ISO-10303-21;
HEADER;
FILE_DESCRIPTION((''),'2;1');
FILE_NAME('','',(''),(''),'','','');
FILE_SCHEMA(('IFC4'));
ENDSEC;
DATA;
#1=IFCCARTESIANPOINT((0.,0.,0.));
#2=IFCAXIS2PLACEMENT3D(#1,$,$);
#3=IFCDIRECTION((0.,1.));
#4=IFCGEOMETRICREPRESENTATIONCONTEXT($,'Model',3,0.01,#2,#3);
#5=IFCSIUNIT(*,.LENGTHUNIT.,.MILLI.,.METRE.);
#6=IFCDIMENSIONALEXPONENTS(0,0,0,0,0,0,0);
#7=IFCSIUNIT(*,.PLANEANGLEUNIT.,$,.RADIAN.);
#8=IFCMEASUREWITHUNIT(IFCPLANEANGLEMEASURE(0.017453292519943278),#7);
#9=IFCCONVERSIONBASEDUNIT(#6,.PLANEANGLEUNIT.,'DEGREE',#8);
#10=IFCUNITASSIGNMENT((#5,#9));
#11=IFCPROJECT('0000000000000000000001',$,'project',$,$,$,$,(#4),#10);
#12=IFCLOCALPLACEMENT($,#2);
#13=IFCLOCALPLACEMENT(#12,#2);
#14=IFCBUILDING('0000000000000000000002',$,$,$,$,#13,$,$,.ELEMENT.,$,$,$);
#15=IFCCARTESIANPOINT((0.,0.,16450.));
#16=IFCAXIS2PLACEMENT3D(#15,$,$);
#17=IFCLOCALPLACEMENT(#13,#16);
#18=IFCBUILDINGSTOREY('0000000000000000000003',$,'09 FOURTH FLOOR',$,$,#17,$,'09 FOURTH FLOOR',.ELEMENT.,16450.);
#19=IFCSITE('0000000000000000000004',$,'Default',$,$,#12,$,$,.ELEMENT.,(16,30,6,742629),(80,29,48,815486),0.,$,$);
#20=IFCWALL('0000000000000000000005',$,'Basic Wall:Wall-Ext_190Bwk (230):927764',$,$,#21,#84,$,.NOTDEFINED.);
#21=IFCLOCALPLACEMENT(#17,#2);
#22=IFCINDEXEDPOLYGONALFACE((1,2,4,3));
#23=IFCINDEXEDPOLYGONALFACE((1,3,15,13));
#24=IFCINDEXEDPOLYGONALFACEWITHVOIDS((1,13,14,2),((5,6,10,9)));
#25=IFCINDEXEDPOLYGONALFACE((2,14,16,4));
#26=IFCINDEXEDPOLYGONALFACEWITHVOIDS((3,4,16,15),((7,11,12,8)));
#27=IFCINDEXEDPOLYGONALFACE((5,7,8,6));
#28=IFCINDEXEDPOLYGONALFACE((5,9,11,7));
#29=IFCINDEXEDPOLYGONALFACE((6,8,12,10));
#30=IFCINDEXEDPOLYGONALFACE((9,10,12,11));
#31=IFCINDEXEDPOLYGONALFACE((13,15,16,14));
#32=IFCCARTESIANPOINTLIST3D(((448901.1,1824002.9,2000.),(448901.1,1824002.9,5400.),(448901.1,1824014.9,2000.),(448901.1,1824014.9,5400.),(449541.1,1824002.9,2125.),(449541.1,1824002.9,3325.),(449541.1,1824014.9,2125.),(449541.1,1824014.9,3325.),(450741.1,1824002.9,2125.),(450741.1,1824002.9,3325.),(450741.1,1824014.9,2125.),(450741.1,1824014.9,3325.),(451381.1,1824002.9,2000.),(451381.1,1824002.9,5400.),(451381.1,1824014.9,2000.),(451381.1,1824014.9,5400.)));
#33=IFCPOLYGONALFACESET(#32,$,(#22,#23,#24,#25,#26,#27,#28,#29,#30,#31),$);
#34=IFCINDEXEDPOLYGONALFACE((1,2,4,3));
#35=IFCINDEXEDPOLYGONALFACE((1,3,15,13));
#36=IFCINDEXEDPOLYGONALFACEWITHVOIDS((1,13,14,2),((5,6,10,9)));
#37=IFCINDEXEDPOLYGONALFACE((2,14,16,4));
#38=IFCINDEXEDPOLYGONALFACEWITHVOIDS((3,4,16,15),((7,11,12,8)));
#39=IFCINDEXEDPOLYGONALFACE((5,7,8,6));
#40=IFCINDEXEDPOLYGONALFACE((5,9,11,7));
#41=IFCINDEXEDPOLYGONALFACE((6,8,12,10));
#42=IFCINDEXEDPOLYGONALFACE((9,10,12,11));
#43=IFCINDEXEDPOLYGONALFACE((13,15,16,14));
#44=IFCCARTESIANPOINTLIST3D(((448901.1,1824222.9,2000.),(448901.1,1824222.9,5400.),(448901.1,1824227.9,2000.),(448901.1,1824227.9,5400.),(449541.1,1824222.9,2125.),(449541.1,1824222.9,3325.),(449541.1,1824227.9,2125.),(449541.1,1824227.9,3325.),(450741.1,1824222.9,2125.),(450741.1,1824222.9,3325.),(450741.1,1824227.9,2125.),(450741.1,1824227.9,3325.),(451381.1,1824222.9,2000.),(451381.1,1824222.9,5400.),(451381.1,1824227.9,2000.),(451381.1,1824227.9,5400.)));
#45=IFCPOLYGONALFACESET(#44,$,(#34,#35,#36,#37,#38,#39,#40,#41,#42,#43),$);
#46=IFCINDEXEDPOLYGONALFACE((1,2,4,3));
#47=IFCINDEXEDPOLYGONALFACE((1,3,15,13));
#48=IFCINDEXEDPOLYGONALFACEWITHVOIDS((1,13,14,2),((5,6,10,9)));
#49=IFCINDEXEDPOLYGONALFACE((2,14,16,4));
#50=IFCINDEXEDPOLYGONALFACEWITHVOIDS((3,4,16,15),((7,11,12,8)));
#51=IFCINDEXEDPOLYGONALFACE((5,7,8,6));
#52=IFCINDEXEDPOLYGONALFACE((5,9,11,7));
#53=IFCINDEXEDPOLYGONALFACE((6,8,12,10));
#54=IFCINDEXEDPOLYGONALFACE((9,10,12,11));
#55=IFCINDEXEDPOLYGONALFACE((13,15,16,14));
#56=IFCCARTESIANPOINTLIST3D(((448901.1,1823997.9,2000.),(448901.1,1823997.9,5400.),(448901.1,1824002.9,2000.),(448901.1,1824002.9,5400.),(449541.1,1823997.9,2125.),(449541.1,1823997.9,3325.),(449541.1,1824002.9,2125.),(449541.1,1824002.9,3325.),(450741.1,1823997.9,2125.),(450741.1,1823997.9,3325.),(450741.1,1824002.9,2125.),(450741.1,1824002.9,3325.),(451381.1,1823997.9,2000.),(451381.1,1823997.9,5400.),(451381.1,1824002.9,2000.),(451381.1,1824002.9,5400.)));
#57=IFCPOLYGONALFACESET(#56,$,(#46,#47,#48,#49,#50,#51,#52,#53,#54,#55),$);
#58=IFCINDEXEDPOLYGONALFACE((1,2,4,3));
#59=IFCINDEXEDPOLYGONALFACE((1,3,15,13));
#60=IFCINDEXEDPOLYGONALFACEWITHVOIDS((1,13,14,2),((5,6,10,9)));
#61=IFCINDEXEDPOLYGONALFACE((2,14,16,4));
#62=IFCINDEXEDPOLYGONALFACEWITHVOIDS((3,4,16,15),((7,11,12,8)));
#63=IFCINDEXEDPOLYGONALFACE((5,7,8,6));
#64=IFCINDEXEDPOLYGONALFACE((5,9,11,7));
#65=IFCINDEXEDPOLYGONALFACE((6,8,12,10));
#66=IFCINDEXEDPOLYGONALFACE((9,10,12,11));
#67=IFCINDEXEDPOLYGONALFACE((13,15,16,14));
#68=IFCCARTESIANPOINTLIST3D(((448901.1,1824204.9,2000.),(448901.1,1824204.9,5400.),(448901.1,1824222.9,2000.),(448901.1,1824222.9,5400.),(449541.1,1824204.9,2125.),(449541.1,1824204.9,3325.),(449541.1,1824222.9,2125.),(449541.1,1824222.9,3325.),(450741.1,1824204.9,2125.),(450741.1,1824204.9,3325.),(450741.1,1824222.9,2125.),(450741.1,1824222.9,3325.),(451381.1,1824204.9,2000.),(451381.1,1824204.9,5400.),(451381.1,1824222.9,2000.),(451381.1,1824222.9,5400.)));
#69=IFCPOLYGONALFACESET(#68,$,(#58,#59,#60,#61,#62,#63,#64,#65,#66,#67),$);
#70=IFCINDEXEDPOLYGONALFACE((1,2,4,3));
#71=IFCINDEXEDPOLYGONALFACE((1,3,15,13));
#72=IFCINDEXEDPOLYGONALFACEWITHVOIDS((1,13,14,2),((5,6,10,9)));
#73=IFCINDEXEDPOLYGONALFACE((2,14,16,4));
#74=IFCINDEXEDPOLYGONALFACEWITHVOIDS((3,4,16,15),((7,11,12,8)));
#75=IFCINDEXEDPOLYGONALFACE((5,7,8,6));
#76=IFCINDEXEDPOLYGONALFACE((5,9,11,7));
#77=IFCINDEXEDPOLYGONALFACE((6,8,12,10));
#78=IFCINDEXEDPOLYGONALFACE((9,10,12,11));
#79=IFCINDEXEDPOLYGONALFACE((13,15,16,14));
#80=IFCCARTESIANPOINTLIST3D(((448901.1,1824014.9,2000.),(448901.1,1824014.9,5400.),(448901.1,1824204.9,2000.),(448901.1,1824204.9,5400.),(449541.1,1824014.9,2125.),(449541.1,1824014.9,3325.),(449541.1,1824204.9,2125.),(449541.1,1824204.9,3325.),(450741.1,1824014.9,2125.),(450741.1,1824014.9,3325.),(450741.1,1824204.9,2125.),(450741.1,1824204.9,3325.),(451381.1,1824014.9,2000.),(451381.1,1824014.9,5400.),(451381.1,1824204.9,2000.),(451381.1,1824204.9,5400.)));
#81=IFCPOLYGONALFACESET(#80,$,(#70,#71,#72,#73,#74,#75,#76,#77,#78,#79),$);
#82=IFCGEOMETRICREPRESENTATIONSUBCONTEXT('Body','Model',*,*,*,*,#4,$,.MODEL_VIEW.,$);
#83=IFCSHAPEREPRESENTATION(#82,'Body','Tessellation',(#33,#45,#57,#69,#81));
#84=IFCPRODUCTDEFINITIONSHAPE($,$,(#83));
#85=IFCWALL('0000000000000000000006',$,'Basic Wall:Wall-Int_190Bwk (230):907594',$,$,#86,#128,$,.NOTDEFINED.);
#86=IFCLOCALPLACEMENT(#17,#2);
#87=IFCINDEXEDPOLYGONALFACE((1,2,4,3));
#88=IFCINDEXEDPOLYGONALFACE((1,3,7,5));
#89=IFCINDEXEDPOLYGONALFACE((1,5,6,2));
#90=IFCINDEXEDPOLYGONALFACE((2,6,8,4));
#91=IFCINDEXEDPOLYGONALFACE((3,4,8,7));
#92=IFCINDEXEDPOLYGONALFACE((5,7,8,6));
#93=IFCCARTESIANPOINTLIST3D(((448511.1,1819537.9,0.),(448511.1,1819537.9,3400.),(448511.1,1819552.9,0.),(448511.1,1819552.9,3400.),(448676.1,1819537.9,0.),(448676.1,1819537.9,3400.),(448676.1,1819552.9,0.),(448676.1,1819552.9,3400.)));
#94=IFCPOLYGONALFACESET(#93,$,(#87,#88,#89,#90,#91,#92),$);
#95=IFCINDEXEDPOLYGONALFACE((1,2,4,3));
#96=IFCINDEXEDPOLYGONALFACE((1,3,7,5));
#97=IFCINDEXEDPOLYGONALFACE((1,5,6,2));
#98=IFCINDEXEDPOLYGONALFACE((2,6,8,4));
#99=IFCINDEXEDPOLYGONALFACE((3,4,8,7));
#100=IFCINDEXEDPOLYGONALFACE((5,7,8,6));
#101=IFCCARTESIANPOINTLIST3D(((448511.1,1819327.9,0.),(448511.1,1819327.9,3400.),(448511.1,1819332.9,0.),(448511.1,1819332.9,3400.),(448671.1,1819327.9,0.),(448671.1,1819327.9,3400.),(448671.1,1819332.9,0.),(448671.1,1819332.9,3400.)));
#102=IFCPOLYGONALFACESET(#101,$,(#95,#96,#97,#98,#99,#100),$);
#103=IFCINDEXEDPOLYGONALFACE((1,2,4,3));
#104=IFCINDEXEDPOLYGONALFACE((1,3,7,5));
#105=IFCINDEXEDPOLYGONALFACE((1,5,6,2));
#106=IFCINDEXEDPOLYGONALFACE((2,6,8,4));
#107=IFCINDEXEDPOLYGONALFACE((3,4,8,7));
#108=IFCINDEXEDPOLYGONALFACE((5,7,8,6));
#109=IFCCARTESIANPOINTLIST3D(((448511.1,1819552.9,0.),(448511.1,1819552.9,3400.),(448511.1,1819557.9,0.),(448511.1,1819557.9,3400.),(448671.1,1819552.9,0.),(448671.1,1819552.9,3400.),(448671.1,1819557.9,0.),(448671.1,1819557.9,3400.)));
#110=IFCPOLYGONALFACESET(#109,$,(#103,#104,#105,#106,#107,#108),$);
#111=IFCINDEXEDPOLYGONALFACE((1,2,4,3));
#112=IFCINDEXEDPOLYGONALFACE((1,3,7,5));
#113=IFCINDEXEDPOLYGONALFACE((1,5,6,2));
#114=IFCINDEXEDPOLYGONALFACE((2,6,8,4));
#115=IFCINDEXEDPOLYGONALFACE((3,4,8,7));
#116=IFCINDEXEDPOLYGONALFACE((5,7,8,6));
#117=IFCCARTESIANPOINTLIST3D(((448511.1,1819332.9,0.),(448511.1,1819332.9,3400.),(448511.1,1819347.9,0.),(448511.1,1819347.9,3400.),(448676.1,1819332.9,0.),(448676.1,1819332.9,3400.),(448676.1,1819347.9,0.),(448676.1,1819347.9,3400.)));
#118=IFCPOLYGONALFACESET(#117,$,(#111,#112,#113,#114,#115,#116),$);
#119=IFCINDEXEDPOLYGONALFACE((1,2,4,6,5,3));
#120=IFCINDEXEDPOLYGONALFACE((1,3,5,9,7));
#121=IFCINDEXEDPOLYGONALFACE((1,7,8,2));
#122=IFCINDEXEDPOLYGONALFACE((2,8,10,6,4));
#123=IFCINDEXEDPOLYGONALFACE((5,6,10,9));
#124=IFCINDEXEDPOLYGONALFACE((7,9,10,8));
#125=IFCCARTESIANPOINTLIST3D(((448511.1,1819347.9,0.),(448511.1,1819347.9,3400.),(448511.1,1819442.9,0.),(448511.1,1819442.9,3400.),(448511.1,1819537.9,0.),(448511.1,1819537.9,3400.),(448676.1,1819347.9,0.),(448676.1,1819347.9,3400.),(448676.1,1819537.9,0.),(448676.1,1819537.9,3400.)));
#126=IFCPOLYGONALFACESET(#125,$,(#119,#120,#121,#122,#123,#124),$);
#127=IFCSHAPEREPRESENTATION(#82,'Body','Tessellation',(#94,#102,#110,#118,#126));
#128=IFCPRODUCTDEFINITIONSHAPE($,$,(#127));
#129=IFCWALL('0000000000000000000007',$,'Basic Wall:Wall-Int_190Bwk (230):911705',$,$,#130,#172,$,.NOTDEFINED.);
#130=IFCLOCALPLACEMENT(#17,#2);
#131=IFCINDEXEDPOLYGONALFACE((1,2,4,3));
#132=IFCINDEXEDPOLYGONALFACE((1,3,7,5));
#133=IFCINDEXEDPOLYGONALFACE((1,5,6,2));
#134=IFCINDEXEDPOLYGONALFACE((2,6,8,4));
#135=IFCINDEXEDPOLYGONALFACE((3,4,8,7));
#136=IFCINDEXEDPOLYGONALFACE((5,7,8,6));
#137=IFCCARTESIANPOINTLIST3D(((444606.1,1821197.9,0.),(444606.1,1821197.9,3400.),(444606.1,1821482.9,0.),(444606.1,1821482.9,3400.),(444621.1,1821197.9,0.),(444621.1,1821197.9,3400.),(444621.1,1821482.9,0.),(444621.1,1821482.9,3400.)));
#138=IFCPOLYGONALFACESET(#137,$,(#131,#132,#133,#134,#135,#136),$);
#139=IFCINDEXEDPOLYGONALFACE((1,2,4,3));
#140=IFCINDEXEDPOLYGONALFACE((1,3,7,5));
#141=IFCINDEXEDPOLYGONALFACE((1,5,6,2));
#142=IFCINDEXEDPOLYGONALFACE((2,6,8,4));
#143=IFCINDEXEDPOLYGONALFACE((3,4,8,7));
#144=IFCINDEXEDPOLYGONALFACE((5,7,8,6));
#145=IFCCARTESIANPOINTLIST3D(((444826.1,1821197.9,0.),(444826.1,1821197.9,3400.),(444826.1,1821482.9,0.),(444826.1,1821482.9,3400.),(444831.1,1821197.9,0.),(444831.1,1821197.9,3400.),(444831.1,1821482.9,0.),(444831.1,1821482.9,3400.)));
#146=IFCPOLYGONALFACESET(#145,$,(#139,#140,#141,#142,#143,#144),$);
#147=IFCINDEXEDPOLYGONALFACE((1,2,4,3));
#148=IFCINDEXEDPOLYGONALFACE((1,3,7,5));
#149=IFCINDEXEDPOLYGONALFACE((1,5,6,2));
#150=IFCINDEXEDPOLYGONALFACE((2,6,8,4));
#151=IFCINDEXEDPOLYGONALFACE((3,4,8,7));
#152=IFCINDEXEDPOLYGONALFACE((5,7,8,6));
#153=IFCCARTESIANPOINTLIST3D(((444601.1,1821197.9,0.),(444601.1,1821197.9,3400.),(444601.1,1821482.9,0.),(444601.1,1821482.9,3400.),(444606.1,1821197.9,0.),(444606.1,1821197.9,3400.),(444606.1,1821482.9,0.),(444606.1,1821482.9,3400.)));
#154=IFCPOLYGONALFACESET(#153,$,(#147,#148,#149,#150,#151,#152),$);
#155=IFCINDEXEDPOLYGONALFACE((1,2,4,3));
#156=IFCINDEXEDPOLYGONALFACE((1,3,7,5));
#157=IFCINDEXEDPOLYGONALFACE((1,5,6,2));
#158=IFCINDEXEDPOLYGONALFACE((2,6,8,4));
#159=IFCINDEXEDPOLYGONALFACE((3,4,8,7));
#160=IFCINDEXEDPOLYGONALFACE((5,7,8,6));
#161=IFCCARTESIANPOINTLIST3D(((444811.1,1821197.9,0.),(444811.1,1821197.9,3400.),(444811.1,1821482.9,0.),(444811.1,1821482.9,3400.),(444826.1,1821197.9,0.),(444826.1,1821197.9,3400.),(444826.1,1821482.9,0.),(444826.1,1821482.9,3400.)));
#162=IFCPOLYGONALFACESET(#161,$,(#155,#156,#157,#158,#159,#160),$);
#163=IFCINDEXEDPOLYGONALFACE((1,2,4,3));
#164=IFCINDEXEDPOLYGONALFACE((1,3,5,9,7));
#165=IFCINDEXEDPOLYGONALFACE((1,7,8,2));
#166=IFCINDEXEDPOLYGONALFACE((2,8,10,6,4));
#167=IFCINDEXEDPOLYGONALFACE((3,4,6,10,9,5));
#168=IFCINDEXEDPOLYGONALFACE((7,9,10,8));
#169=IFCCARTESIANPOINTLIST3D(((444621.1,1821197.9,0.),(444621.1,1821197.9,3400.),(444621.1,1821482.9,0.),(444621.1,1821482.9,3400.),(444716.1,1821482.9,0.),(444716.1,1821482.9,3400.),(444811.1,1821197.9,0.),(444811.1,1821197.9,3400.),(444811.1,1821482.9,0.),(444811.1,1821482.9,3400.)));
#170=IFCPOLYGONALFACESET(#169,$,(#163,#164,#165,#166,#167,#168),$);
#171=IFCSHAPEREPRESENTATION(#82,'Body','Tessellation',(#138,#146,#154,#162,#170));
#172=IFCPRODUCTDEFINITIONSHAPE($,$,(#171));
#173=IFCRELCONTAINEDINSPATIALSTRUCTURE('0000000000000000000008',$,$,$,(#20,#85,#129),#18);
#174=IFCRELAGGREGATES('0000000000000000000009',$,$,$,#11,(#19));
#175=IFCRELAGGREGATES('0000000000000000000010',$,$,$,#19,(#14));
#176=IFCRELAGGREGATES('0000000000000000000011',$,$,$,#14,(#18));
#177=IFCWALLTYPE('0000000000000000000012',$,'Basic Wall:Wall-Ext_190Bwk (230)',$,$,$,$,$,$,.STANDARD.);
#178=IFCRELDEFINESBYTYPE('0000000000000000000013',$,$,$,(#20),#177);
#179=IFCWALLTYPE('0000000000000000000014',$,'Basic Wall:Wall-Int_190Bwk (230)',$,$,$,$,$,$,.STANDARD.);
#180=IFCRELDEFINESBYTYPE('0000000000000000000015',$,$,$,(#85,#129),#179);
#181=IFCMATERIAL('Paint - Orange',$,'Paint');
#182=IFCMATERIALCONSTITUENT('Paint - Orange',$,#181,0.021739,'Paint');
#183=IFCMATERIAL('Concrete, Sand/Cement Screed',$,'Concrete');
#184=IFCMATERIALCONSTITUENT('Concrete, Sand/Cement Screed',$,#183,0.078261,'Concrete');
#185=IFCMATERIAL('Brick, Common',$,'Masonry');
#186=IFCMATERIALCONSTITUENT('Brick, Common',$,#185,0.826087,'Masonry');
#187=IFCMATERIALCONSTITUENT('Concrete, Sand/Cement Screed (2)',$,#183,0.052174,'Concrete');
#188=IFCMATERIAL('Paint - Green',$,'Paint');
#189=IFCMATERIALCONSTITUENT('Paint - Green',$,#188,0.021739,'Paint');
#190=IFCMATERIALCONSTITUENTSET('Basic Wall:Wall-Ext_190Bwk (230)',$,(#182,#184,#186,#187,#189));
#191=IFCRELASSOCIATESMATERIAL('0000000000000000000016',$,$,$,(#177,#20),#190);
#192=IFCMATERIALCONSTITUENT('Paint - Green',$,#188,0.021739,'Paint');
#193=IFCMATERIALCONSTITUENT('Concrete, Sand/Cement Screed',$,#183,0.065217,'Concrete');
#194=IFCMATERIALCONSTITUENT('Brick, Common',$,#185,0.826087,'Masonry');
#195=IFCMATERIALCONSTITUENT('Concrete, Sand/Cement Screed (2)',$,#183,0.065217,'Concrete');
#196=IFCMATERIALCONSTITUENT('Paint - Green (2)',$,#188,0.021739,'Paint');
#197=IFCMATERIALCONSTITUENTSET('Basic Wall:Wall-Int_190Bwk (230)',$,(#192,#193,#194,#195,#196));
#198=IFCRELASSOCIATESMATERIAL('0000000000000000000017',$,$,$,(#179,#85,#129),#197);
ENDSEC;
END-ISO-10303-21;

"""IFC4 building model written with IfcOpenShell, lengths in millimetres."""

from ifc_helpers import new_model, entity, si_unit, converted_unit, direction, frame, origin, place, context, subcontext, project, spatial, indexed_curve, outline, extrude, material, constituent, constituent_set, type_object, element, save


model = new_model("IFC4")

# Units and contexts
model_context = context("Model", 3, precision=0.01, world=origin(), true_north=direction((0.0, 1.0)))
body_context = subcontext(model_context, "Body", "Model", "MODEL_VIEW")
ifc_project = project(units=[si_unit("LENGTHUNIT", "METRE", prefix="MILLI"), converted_unit("PLANEANGLEUNIT", "DEGREE", entity("IfcPlaneAngleMeasure", 0.017453292519943278), si_unit("PLANEANGLEUNIT", "RADIAN"), dimensions=[0, 0, 0, 0, 0, 0, 0])], contexts=[model_context])

# Site, building, storey
site_placement = place(None, origin())
site = spatial("IfcSite", under=ifc_project, at=site_placement, Name="Default", CompositionType="ELEMENT", RefLatitude=(16, 30, 6, 742629), RefLongitude=(80, 29, 48, 815486), RefElevation=0.0)
building_placement = place(site_placement, origin())
building = spatial("IfcBuilding", under=site, at=building_placement, CompositionType="ELEMENT")
storey_placement = place(building_placement, frame((0.0, 0.0, 16450.0)))
storey = spatial("IfcBuildingStorey", under=building, at=storey_placement, Name="09 FOURTH FLOOR", LongName="09 FOURTH FLOOR", CompositionType="ELEMENT", Elevation=16450.0)

# Shared definitions
ifc_material_1 = material(Name="Concrete, Sand/Cement Screed", Category="Concrete")
ifc_material_2 = material(Name="Brick, Common", Category="Masonry")

# Shared definitions
ifc_material_3 = material(Name="Paint - Orange", Category="Paint")
ifc_constituent_1 = constituent(ifc_material_3, Name="Paint - Orange", Category="Paint", fraction=0.021739)
ifc_constituent_2 = constituent(ifc_material_1, Name="Concrete, Sand/Cement Screed", Category="Concrete", fraction=0.078261)
ifc_constituent_3 = constituent(ifc_material_2, Name="Brick, Common", Category="Masonry", fraction=0.826087)
ifc_constituent_4 = constituent(ifc_material_1, Name="Concrete, Sand/Cement Screed (2)", Category="Concrete", fraction=0.052174)
ifc_material_4 = material(Name="Paint - Green", Category="Paint")
ifc_constituent_5 = constituent(ifc_material_4, Name="Paint - Green", Category="Paint", fraction=0.021739)
ifc_constituent_set_1 = constituent_set(constituents=[ifc_constituent_1, ifc_constituent_2, ifc_constituent_3, ifc_constituent_4, ifc_constituent_5], Name="Basic Wall:Wall-Ext_190Bwk (230)")
wall_type_1 = type_object("IfcWallType", Name="Basic Wall:Wall-Ext_190Bwk (230)", PredefinedType="STANDARD", material=ifc_constituent_set_1)

# Wall, opening
wall_1_placement = place(storey_placement, frame((448901.1, 1824112.9, 2000.0)))
wall_1 = element("IfcWall", 1, at=wall_1_placement, inside=storey, type_object=wall_type_1, material=ifc_constituent_set_1, Name="Basic Wall:Wall-Ext_190Bwk (230):927764", PredefinedType="NOTDEFINED", context=body_context, shape_type="SweptSolid", body=[
    extrude(outline(indexed_curve([(-1700.0, -1240.0), (1700.0, -1240.0), (1700.0, 1240.0), (-1700.0, 1240.0), (-1700.0, -1240.0)], self_intersect=False), holes=[indexed_curve([(-1575.0, -600.0), (-1575.0, 600.0), (-375.0, 600.0), (-375.0, -600.0), (-1575.0, -600.0)], self_intersect=False)]), frame((1240.0, -110.0, 1700.0), z_axis=(0.0, 1.0, 0.0), x_axis=(0.0, 0.0, 1.0)), (0.0, 0.0, 1.0), 12.0),
    extrude(outline(indexed_curve([(-1700.0, -1240.0), (1700.0, -1240.0), (1700.0, 1240.0), (-1700.0, 1240.0), (-1700.0, -1240.0)], self_intersect=False), holes=[indexed_curve([(-1575.0, -600.0), (-1575.0, 600.0), (-375.0, 600.0), (-375.0, -600.0), (-1575.0, -600.0)], self_intersect=False)]), frame((1240.0, 110.0, 1700.0), z_axis=(0.0, 1.0, 0.0), x_axis=(0.0, 0.0, 1.0)), (0.0, 0.0, 1.0), 5.0),
    extrude(outline(indexed_curve([(-1700.0, -1240.0), (1700.0, -1240.0), (1700.0, 1240.0), (-1700.0, 1240.0), (-1700.0, -1240.0)], self_intersect=False), holes=[indexed_curve([(-375.0, -600.0), (-1575.0, -600.0), (-1575.0, 600.0), (-375.0, 600.0), (-375.0, -600.0)], self_intersect=False)]), frame((1240.0, -115.0, 1700.0), z_axis=(0.0, 1.0, 0.0), x_axis=(0.0, 0.0, 1.0)), (0.0, 0.0, 1.0), 5.0),
    extrude(outline(indexed_curve([(-1700.0, -1240.0), (1700.0, -1240.0), (1700.0, 1240.0), (-1700.0, 1240.0), (-1700.0, -1240.0)], self_intersect=False), holes=[indexed_curve([(-1575.0, -600.0), (-1575.0, 600.0), (-375.0, 600.0), (-375.0, -600.0), (-1575.0, -600.0)], self_intersect=False)]), frame((1240.0, 92.0, 1700.0), z_axis=(0.0, 1.0, 0.0), x_axis=(0.0, 0.0, 1.0)), (0.0, 0.0, 1.0), 18.0),
    extrude(outline(indexed_curve([(-1700.0, -1240.0), (1700.0, -1240.0), (1700.0, 1240.0), (-1700.0, 1240.0), (-1700.0, -1240.0)], self_intersect=False), holes=[indexed_curve([(-1575.0, -600.0), (-1575.0, 600.0), (-375.0, 600.0), (-375.0, -600.0), (-1575.0, -600.0)], self_intersect=False)]), frame((1240.0, -98.0, 1700.0), z_axis=(0.0, 1.0, 0.0), x_axis=(0.0, 0.0, 1.0)), (0.0, 0.0, 1.0), 190.0),
])
opening_1_placement = place(wall_1_placement, frame((640.0, -115.0, 125.0)))
element("IfcOpeningElement", 2, at=opening_1_placement, cuts=wall_1, PredefinedType="OPENING", context=body_context, shape_type="SweptSolid", body=[
    extrude(outline(indexed_curve([(1200.0, 0.0), (1200.0, 1200.0), (0.0, 1200.0), (0.0, 0.0), (1200.0, 0.0)], self_intersect=False)), frame((0.0, 0.0, 0.0), z_axis=(0.0, 1.0, 0.0), x_axis=(0.0, 0.0, 1.0)), (0.0, 0.0, 1.0), 230.0),
])

# Shared definitions
ifc_constituent_6 = constituent(ifc_material_4, Name="Paint - Green", Category="Paint", fraction=0.021739)
ifc_constituent_7 = constituent(ifc_material_1, Name="Concrete, Sand/Cement Screed", Category="Concrete", fraction=0.065217)
ifc_constituent_8 = constituent(ifc_material_2, Name="Brick, Common", Category="Masonry", fraction=0.826087)
ifc_constituent_9 = constituent(ifc_material_1, Name="Concrete, Sand/Cement Screed (2)", Category="Concrete", fraction=0.065217)
ifc_constituent_10 = constituent(ifc_material_4, Name="Paint - Green (2)", Category="Paint", fraction=0.021739)
ifc_constituent_set_2 = constituent_set(constituents=[ifc_constituent_6, ifc_constituent_7, ifc_constituent_8, ifc_constituent_9, ifc_constituent_10], Name="Basic Wall:Wall-Int_190Bwk (230)")
wall_type_2 = type_object("IfcWallType", Name="Basic Wall:Wall-Int_190Bwk (230)", PredefinedType="STANDARD", material=ifc_constituent_set_2)

# Walls
wall_2_placement = place(storey_placement, frame((448671.1, 1819442.9, 0.0), z_axis=(0.0, 0.0, 1.0), x_axis=(-1.0, 0.0, 0.0)))
element("IfcWall", 3, at=wall_2_placement, inside=storey, type_object=wall_type_2, material=ifc_constituent_set_2, Name="Basic Wall:Wall-Int_190Bwk (230):907594", PredefinedType="NOTDEFINED", context=body_context, shape_type="SweptSolid", body=[
    extrude(outline(indexed_curve([(-82.5, -7.5), (82.5, -7.5), (82.5, 7.5), (-82.5, 7.5), (-82.5, -7.5)], self_intersect=False)), frame((77.5, -102.5, 0.0)), (0.0, 0.0, 1.0), 3400.0),
    extrude(outline(indexed_curve([(-2.5, -80.0), (2.5, -80.0), (2.5, 80.0), (-2.5, 80.0), (-2.5, -80.0)], self_intersect=False)), frame((80.0, 112.5, 0.0), z_axis=(0.0, 0.0, 1.0), x_axis=(0.0, -1.0, 0.0)), (0.0, 0.0, 1.0), 3400.0),
    extrude(outline(indexed_curve([(-2.5, -80.0), (2.5, -80.0), (2.5, 80.0), (-2.5, 80.0), (-2.5, -80.0)], self_intersect=False)), frame((80.0, -112.5, 0.0), z_axis=(0.0, 0.0, 1.0), x_axis=(0.0, 1.0, 0.0)), (0.0, 0.0, 1.0), 3400.0),
    extrude(outline(indexed_curve([(-82.5, -7.5), (82.5, -7.5), (82.5, 7.5), (-82.5, 7.5), (-82.5, -7.5)], self_intersect=False)), frame((77.5, 102.5, 0.0)), (0.0, 0.0, 1.0), 3400.0),
    extrude(outline(indexed_curve([(-99.0, -95.0), (66.0, -95.0), (66.0, 0.0), (66.0, 95.0), (-99.0, 95.0), (-99.0, -95.0)], self_intersect=False)), frame((94.0, 0.0, 0.0)), (0.0, 0.0, 1.0), 3400.0),
])
wall_3_placement = place(storey_placement, frame((444716.1, 1821197.9, 0.0), z_axis=(0.0, 0.0, 1.0), x_axis=(0.0, 1.0, 0.0)))
element("IfcWall", 4, at=wall_3_placement, inside=storey, type_object=wall_type_2, material=ifc_constituent_set_2, Name="Basic Wall:Wall-Int_190Bwk (230):911705", PredefinedType="NOTDEFINED", context=body_context, shape_type="SweptSolid", body=[
    extrude(outline(indexed_curve([(-142.5, -7.5), (142.5, -7.5), (142.5, 7.5), (-142.5, 7.5), (-142.5, -7.5)], self_intersect=False)), frame((142.5, 102.5, 0.0)), (0.0, 0.0, 1.0), 3400.0),
    extrude(outline(indexed_curve([(-2.5, -142.5), (2.5, -142.5), (2.5, 142.5), (-2.5, 142.5), (-2.5, -142.5)], self_intersect=False)), frame((142.5, -112.5, 0.0), z_axis=(0.0, 0.0, 1.0), x_axis=(0.0, 1.0, 0.0)), (0.0, 0.0, 1.0), 3400.0),
    extrude(outline(indexed_curve([(-2.5, -142.5), (2.5, -142.5), (2.5, 142.5), (-2.5, 142.5), (-2.5, -142.5)], self_intersect=False)), frame((142.5, 112.5, 0.0), z_axis=(0.0, 0.0, 1.0), x_axis=(0.0, -1.0, 0.0)), (0.0, 0.0, 1.0), 3400.0),
    extrude(outline(indexed_curve([(-142.5, -7.5), (142.5, -7.5), (142.5, 7.5), (-142.5, 7.5), (-142.5, -7.5)], self_intersect=False)), frame((142.5, -102.5, 0.0)), (0.0, 0.0, 1.0), 3400.0),
    extrude(outline(indexed_curve([(-171.0, -95.0), (114.0, -95.0), (114.0, 0.0), (114.0, 95.0), (-171.0, 95.0), (-171.0, -95.0)], self_intersect=False)), frame((171.0, 0.0, 0.0)), (0.0, 0.0, 1.0), 3400.0),
])

save(model, "model.ifc")
